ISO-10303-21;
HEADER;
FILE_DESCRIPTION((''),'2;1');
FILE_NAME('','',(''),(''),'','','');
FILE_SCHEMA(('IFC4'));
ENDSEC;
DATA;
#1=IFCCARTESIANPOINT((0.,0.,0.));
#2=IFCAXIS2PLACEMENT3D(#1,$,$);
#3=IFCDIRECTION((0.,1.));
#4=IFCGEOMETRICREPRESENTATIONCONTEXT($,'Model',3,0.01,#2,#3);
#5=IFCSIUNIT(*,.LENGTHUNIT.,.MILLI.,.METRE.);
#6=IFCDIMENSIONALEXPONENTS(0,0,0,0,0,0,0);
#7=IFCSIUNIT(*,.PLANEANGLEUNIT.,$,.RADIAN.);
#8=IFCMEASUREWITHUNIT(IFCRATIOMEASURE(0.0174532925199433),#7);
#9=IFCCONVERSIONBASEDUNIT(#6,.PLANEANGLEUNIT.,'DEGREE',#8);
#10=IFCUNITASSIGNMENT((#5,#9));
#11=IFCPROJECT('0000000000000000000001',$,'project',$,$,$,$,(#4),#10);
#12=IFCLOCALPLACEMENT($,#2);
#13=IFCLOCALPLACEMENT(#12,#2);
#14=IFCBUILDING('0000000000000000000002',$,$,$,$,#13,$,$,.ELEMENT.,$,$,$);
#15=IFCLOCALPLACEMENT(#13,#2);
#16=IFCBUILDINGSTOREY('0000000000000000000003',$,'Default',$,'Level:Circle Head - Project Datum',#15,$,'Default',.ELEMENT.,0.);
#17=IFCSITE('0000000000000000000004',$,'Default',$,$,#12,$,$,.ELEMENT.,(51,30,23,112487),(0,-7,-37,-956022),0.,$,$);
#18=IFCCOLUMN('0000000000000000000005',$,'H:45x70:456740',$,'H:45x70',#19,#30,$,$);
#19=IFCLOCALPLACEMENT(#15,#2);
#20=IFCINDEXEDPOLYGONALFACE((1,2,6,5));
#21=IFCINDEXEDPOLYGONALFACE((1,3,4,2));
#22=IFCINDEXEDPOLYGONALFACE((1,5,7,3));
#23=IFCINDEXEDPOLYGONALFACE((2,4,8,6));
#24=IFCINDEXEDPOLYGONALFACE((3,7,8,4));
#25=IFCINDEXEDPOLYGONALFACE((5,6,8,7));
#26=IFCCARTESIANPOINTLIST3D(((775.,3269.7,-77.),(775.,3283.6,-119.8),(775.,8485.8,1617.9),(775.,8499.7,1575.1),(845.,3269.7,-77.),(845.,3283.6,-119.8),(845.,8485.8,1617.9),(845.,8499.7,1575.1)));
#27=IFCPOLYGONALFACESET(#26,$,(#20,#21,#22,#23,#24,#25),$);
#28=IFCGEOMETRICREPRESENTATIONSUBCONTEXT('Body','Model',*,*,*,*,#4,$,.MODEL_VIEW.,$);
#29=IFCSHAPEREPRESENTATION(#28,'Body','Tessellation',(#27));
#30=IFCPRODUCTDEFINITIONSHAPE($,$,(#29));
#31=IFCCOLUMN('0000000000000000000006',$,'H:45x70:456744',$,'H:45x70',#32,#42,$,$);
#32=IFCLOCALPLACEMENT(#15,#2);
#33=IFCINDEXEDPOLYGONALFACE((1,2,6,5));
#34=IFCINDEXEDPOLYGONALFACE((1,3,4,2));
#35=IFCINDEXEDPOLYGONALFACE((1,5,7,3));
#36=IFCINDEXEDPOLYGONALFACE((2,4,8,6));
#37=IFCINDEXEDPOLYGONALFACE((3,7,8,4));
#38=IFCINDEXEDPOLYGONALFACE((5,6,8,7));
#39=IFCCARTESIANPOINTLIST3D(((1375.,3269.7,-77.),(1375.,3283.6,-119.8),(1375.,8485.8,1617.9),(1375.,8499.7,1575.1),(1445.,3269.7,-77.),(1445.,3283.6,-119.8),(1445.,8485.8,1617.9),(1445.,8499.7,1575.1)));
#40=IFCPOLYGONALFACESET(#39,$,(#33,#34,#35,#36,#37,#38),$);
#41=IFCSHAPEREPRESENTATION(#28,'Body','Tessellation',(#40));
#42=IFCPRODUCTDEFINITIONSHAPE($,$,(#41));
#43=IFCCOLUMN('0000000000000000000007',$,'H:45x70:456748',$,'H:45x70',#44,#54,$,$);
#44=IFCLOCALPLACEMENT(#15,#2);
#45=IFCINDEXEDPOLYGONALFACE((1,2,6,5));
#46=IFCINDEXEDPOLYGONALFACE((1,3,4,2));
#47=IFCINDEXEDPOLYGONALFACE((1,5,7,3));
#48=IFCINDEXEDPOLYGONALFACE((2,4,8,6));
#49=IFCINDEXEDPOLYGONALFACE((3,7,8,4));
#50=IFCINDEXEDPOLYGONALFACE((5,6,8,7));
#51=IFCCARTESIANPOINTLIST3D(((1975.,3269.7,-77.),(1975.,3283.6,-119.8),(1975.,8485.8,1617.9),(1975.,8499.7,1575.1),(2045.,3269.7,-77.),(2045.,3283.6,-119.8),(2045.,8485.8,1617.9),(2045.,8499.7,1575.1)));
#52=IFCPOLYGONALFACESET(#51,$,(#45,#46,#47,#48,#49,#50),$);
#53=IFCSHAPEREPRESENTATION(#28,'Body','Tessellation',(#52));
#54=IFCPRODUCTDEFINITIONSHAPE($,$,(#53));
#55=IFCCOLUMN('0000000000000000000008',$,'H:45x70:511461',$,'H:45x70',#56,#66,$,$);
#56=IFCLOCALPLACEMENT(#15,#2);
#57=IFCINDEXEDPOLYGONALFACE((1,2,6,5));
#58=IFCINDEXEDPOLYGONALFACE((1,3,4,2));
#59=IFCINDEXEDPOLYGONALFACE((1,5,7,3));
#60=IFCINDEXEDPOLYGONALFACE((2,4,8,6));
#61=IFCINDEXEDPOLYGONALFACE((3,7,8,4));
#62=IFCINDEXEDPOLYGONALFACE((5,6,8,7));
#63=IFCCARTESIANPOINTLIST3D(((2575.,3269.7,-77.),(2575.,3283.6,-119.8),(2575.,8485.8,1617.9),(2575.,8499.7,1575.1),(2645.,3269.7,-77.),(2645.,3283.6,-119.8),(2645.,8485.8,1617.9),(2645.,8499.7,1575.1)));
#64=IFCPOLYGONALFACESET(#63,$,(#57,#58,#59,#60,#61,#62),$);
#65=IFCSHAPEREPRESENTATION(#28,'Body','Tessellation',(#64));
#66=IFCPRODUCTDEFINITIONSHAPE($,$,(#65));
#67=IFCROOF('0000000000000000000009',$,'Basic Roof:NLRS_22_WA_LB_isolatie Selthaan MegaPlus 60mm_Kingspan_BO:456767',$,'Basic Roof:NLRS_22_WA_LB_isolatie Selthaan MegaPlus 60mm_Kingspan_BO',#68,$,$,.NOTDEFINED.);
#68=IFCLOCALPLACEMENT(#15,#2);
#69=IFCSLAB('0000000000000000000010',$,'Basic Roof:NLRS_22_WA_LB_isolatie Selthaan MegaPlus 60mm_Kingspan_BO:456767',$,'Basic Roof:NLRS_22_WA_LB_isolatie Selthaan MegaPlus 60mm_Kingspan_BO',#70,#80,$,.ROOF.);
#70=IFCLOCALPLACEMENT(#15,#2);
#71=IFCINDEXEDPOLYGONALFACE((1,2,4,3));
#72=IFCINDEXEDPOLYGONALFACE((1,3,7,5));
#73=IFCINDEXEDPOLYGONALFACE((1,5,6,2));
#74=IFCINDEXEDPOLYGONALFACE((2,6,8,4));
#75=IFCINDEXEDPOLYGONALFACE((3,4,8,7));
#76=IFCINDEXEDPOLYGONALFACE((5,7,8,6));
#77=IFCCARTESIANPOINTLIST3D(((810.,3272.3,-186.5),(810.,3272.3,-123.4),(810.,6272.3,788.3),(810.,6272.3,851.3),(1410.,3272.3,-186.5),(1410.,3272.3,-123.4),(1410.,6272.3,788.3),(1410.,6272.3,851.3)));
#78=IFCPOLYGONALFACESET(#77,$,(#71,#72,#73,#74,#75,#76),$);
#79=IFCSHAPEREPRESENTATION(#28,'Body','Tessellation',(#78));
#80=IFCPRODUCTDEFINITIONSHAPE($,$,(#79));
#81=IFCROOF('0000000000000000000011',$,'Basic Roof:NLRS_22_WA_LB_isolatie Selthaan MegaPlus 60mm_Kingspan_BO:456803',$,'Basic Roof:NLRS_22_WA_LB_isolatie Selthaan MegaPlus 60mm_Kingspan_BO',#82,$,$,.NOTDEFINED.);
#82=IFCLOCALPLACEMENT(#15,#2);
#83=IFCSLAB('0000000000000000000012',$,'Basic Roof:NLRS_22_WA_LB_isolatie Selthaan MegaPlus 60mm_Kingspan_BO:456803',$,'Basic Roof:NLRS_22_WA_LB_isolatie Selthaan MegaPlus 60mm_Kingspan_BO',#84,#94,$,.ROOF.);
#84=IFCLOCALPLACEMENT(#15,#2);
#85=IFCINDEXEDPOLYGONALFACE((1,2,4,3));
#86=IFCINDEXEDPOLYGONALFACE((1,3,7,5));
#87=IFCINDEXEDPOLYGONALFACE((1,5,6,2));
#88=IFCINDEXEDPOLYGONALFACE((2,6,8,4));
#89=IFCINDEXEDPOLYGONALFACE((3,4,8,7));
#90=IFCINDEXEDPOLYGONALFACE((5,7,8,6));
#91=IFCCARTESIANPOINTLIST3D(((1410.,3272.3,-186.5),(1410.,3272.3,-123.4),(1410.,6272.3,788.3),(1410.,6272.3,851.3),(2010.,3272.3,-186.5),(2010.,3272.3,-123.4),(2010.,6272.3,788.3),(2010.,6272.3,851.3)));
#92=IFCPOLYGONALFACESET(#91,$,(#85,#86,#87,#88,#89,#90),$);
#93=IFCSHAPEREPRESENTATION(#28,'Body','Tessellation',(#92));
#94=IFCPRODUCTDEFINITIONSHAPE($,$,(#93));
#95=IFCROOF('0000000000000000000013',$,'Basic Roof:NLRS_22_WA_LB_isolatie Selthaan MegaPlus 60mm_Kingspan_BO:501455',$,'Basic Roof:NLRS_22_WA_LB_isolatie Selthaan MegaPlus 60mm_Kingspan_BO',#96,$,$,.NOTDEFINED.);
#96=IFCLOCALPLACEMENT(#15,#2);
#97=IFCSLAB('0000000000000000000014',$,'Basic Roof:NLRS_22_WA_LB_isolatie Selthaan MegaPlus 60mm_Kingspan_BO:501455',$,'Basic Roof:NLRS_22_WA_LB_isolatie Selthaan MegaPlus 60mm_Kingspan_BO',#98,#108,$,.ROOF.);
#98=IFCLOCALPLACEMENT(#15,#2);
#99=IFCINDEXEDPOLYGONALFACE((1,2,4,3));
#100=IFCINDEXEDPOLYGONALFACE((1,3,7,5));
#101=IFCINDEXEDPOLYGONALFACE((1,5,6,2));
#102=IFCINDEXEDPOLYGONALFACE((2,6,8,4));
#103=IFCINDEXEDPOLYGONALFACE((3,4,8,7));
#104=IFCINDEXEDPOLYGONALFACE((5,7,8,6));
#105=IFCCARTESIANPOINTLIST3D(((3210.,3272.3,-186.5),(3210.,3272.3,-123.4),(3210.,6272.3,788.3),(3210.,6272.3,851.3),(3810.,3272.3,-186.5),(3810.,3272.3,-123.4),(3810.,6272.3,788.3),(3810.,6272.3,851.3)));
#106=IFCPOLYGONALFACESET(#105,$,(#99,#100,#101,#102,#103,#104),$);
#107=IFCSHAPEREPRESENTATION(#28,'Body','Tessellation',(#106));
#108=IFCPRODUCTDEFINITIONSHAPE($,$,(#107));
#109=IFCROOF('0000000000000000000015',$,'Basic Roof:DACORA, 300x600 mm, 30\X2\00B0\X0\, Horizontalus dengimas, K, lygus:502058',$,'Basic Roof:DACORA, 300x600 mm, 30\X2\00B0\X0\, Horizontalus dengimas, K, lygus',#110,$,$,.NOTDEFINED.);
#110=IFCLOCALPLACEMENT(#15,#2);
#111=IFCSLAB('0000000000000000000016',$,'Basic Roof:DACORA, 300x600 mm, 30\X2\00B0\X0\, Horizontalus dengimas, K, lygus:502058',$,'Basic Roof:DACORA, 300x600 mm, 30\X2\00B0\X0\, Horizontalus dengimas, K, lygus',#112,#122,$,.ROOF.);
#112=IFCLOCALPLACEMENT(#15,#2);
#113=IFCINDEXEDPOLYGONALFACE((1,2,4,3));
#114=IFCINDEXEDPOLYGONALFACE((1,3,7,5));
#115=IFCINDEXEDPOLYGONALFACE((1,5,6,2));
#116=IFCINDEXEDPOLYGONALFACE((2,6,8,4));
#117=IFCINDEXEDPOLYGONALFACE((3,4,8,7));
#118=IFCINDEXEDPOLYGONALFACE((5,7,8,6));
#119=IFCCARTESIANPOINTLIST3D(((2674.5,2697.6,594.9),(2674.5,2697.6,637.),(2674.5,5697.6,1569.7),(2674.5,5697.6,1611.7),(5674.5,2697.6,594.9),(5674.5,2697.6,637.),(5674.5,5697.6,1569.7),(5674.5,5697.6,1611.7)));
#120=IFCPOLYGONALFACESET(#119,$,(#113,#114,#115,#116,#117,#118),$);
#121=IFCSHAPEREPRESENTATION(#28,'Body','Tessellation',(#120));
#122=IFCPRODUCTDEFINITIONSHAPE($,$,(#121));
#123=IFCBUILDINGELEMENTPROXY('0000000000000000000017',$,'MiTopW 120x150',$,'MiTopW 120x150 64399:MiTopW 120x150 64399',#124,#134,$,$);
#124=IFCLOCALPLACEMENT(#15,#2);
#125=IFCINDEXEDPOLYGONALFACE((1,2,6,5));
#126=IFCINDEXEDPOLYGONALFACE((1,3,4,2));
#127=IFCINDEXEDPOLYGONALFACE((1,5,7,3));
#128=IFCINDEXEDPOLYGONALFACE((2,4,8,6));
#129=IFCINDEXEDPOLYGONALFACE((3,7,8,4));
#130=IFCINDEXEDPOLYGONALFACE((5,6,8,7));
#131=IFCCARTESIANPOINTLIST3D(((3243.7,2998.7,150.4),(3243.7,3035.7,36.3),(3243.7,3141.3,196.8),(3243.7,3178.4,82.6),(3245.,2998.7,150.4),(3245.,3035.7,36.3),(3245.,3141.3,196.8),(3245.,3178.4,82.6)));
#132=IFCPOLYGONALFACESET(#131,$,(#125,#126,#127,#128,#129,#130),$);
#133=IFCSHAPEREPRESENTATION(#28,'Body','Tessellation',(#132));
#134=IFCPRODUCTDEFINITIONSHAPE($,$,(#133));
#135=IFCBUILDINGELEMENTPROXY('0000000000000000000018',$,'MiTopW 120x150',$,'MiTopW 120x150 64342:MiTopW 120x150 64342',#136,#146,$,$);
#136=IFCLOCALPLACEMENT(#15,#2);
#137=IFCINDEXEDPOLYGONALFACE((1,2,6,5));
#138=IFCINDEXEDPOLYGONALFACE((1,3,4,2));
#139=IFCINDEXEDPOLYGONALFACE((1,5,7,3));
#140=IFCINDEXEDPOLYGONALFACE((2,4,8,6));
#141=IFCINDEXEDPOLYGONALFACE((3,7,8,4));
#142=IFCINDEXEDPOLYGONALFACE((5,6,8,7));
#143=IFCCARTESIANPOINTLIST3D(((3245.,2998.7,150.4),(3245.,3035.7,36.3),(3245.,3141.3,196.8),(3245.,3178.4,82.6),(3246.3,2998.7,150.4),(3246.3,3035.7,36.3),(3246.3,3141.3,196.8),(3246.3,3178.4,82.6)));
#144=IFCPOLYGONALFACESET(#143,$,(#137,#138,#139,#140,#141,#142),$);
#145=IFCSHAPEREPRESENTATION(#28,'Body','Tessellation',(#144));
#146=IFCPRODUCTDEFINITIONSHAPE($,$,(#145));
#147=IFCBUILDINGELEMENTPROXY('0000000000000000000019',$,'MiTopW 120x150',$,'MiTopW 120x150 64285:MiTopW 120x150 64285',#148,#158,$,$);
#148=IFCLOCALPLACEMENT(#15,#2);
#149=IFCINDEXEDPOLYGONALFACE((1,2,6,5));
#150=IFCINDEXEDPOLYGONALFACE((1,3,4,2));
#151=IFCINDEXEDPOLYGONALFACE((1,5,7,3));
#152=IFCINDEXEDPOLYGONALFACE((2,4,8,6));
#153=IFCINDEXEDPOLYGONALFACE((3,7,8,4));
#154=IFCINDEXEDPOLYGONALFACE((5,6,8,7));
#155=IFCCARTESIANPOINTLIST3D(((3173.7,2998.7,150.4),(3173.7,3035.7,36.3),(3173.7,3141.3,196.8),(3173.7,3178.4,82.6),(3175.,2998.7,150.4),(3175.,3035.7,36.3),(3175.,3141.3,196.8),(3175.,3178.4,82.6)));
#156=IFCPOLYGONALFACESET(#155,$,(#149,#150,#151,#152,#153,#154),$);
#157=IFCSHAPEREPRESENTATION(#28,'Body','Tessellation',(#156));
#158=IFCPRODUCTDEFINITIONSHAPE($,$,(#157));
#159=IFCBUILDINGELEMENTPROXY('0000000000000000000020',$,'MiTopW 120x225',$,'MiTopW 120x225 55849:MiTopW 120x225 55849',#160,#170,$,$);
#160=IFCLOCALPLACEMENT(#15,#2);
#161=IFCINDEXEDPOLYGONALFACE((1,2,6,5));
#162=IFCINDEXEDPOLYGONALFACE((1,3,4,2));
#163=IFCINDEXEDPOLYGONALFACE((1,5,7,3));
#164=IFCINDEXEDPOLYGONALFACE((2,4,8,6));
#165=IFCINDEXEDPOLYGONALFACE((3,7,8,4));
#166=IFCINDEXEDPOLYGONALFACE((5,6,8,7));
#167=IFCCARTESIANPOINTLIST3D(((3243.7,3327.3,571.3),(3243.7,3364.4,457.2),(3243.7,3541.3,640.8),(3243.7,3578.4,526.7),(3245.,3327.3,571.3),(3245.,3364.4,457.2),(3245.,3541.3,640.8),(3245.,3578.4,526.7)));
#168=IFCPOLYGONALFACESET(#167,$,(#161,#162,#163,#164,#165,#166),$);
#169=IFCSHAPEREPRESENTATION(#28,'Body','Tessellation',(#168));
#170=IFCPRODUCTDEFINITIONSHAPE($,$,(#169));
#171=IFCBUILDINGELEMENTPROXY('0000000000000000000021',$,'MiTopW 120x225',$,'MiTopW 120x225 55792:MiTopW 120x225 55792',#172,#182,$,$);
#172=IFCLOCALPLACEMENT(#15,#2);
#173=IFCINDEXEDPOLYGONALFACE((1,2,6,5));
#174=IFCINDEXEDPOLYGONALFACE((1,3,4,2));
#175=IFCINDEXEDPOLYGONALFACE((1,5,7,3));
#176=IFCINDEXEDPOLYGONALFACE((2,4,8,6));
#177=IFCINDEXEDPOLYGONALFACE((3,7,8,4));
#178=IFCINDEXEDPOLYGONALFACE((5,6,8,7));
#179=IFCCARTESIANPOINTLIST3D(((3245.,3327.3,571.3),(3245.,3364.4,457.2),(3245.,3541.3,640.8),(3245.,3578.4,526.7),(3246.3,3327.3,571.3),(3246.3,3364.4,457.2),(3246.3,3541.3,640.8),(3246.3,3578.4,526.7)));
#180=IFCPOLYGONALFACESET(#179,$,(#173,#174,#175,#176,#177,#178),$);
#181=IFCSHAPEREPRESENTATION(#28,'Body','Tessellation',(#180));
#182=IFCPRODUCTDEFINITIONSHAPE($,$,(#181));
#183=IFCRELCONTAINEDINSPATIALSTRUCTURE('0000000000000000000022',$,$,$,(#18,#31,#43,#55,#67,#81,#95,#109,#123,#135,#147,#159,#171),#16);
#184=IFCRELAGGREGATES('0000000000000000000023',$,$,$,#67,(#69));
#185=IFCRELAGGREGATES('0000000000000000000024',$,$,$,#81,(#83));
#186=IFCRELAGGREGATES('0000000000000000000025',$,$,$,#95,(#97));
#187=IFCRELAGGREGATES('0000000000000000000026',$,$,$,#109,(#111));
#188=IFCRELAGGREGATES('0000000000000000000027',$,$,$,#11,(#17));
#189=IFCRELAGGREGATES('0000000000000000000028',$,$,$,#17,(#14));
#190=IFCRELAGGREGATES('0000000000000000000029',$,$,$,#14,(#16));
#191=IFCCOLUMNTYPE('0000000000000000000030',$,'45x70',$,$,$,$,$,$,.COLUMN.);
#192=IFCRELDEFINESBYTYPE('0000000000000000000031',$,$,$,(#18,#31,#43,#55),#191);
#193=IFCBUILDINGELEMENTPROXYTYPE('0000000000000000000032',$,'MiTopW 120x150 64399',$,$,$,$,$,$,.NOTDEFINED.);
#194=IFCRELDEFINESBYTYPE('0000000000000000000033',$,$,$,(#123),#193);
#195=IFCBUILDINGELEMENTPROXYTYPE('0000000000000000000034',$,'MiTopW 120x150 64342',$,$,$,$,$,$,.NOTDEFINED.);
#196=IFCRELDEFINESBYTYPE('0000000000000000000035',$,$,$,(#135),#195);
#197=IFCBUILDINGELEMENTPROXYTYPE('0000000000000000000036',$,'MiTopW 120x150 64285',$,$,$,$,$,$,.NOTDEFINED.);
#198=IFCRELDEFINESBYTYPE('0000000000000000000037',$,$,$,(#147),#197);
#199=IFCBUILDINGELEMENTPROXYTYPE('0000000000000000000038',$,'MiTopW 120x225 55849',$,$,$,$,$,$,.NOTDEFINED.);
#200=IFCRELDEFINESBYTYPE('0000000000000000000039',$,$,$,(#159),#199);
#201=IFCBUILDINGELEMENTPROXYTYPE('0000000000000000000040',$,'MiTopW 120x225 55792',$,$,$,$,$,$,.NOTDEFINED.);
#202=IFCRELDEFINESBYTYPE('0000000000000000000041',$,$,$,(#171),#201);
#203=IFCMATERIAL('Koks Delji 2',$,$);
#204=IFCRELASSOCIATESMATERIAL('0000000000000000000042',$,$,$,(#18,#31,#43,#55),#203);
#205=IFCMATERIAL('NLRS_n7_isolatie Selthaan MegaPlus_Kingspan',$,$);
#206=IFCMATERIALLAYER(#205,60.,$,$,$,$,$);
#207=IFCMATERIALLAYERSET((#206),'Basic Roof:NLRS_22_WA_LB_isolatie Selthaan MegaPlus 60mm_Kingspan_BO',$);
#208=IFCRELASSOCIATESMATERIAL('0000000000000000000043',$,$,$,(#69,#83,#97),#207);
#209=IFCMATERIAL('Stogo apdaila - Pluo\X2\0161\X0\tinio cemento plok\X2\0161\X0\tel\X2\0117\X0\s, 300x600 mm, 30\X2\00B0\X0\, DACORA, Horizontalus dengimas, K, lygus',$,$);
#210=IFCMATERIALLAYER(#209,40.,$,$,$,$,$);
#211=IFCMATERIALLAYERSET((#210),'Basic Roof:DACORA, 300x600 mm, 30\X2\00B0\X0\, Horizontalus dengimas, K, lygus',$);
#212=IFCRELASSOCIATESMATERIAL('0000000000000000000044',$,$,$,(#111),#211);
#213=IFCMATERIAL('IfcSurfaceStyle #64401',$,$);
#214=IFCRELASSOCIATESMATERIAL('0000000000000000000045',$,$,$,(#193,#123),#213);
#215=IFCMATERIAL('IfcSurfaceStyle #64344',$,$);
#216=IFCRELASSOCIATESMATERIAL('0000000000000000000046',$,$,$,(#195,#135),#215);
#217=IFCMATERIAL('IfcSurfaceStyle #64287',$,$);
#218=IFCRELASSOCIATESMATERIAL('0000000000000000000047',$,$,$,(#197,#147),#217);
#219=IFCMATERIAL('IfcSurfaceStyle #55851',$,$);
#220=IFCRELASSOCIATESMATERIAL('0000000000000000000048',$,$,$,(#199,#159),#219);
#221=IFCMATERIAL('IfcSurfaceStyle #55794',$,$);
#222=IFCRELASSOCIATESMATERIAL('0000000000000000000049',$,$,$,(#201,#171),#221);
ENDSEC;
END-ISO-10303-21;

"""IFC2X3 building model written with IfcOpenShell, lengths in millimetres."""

from ifc_helpers import new_model, entity, si_unit, converted_unit, direction, frame, frame_2d, origin, place, context, subcontext, project, spatial, polyline, rectangle, outline, extrude, source, transform, mapped, material, layer, layer_set, type_object, type_shapes, element, aggregate, save


model = new_model("IFC2X3")

# Units and contexts
model_context = context("Model", 3, precision=0.01, world=origin(), true_north=direction((0.0, 1.0)))
body_context = subcontext(model_context, "Body", "Model", "MODEL_VIEW")
ifc_project = project(units=[si_unit("LENGTHUNIT", "METRE", prefix="MILLI"), converted_unit("PLANEANGLEUNIT", "DEGREE", entity("IfcRatioMeasure", 0.0174532925199433), si_unit("PLANEANGLEUNIT", "RADIAN"), dimensions=[0, 0, 0, 0, 0, 0, 0])], contexts=[model_context])

# Site, building, storey
site_placement = place(None, origin())
site = spatial("IfcSite", under=ifc_project, at=site_placement, Name="Default", CompositionType="ELEMENT", RefLatitude=(51, 30, 23, 112487), RefLongitude=(0, -7, -37, -956022), RefElevation=0.0)
building_placement = place(site_placement, origin())
building = spatial("IfcBuilding", under=site, at=building_placement, CompositionType="ELEMENT")
storey_placement = place(building_placement, origin())
storey = spatial("IfcBuildingStorey", under=building, at=storey_placement, Name="Default", ObjectType="Level:Circle Head - Project Datum", LongName="Default", CompositionType="ELEMENT", Elevation=0.0)

# Columns
ifc_material_1 = material(Name="Koks Delji 2")
column_type_1 = type_object("IfcColumnType", Name="45x70", PredefinedType="COLUMN")
shared_shape_1 = source(origin(), body_context, "Body", "SweptSolid", [
    extrude(rectangle(XDim=5484.5, YDim=70.0, at=frame_2d((0.0, 0.0), x_axis=(1.0, 0.0))), frame((2608.0, 237.8, 847.4), z_axis=(-0.309017, 0.0, 0.951057), x_axis=(-0.951057, 0.0, -0.309017)), (0.0, 0.0, 1.0), 45.0),
])
type_shapes(column_type_1, [shared_shape_1])
for number, where, z_axis, x_axis, name in (
    (1, (1047.8, 3283.6, -119.8), (0.0, 0.0, 1.0), (0.0, 1.0, 0.0), "H:45x70:456740"),
    (2, (1647.8, 3283.6, -119.8), (0.0, 0.0, 1.0), (0.0, 1.0, 0.0), "H:45x70:456744"),
    (3, (2247.8, 3283.6, -119.8), (0.0, 0.0, 1.0), (0.0, 1.0, 0.0), "H:45x70:456748"),
    (4, (2847.8, 3283.6, -119.8), (0.0, 0.0, 1.0), (0.0, 1.0, 0.0), "H:45x70:511461"),
):
    element("IfcColumn", number, at=place(storey_placement, frame(where, z_axis=z_axis, x_axis=x_axis)), inside=storey, type_object=column_type_1, material=ifc_material_1, Name=name, ObjectType="H:45x70", context=body_context, shape_type="MappedRepresentation", body=[
        mapped(shared_shape_1, transform((0.0, 0.0, 0.0), scale=1.0)),
    ])

# Roofs, slabs
roof_1_placement = place(storey_placement, frame((810.0, 3272.3, -186.5)))
roof_1 = element("IfcRoof", 5, at=roof_1_placement, inside=storey, Name="Basic Roof:NLRS_22_WA_LB_isolatie Selthaan MegaPlus 60mm_Kingspan_BO:456767", ObjectType="Basic Roof:NLRS_22_WA_LB_isolatie Selthaan MegaPlus 60mm_Kingspan_BO", ShapeType="NOTDEFINED")
ifc_material_2 = material(Name="NLRS_n7_isolatie Selthaan MegaPlus_Kingspan")
ifc_layer_1 = layer(ifc_material_2, 60.0)
ifc_layer_set_1 = layer_set([ifc_layer_1], Name="Basic Roof:NLRS_22_WA_LB_isolatie Selthaan MegaPlus 60mm_Kingspan_BO")
slab_1_placement = place(roof_1_placement, origin())
slab_1 = element("IfcSlab", 6, at=slab_1_placement, material=ifc_layer_set_1, Name="Basic Roof:NLRS_22_WA_LB_isolatie Selthaan MegaPlus 60mm_Kingspan_BO:456767", ObjectType="Basic Roof:NLRS_22_WA_LB_isolatie Selthaan MegaPlus 60mm_Kingspan_BO", PredefinedType="ROOF", context=body_context, shape_type="SweptSolid", body=[
    extrude(rectangle(XDim=600.0, YDim=3154.4, at=frame_2d((0.0, 0.0), x_axis=(-1.0, 0.0))), frame((300.0, 1500.0, 487.4), z_axis=(0.0, -0.309017, 0.951057), x_axis=(1.0, 0.0, 0.0)), (0.0, 0.309017, 0.951057), 63.1),
])
aggregate(roof_1, [slab_1])
roof_2_placement = place(storey_placement, frame((1410.0, 3272.3, -186.5)))
roof_2 = element("IfcRoof", 7, at=roof_2_placement, inside=storey, Name="Basic Roof:NLRS_22_WA_LB_isolatie Selthaan MegaPlus 60mm_Kingspan_BO:456803", ObjectType="Basic Roof:NLRS_22_WA_LB_isolatie Selthaan MegaPlus 60mm_Kingspan_BO", ShapeType="NOTDEFINED")
slab_2_placement = place(roof_2_placement, origin())
slab_2 = element("IfcSlab", 8, at=slab_2_placement, material=ifc_layer_set_1, Name="Basic Roof:NLRS_22_WA_LB_isolatie Selthaan MegaPlus 60mm_Kingspan_BO:456803", ObjectType="Basic Roof:NLRS_22_WA_LB_isolatie Selthaan MegaPlus 60mm_Kingspan_BO", PredefinedType="ROOF", context=body_context, shape_type="SweptSolid", body=[
    extrude(rectangle(XDim=600.0, YDim=3154.4, at=frame_2d((0.0, 0.0), x_axis=(-1.0, 0.0))), frame((300.0, 1500.0, 487.4), z_axis=(0.0, -0.309017, 0.951057), x_axis=(1.0, 0.0, 0.0)), (0.0, 0.309017, 0.951057), 63.1),
])
aggregate(roof_2, [slab_2])
roof_3_placement = place(storey_placement, frame((3210.0, 3272.3, -186.5)))
roof_3 = element("IfcRoof", 9, at=roof_3_placement, inside=storey, Name="Basic Roof:NLRS_22_WA_LB_isolatie Selthaan MegaPlus 60mm_Kingspan_BO:501455", ObjectType="Basic Roof:NLRS_22_WA_LB_isolatie Selthaan MegaPlus 60mm_Kingspan_BO", ShapeType="NOTDEFINED")
slab_3_placement = place(roof_3_placement, origin())
slab_3 = element("IfcSlab", 10, at=slab_3_placement, material=ifc_layer_set_1, Name="Basic Roof:NLRS_22_WA_LB_isolatie Selthaan MegaPlus 60mm_Kingspan_BO:501455", ObjectType="Basic Roof:NLRS_22_WA_LB_isolatie Selthaan MegaPlus 60mm_Kingspan_BO", PredefinedType="ROOF", context=body_context, shape_type="SweptSolid", body=[
    extrude(rectangle(XDim=600.0, YDim=3154.4, at=frame_2d((0.0, 0.0), x_axis=(-1.0, 0.0))), frame((300.0, 1500.0, 487.4), z_axis=(0.0, -0.309017, 0.951057), x_axis=(1.0, 0.0, 0.0)), (0.0, 0.309017, 0.951057), 63.1),
])
aggregate(roof_3, [slab_3])
roof_4_placement = place(storey_placement, frame((2674.5, 2697.6, 594.9)))
roof_4 = element("IfcRoof", 11, at=roof_4_placement, inside=storey, Name="Basic Roof:DACORA, 300x600 mm, 30°, Horizontalus dengimas, K, lygus:502058", ObjectType="Basic Roof:DACORA, 300x600 mm, 30°, Horizontalus dengimas, K, lygus", ShapeType="NOTDEFINED")
ifc_material_3 = material(Name="Stogo apdaila - Pluoštinio cemento plokštelės, 300x600 mm, 30°, DACORA, Horizontalus dengimas, K, lygus")
ifc_layer_2 = layer(ifc_material_3, 40.0)
ifc_layer_set_2 = layer_set([ifc_layer_2], Name="Basic Roof:DACORA, 300x600 mm, 30°, Horizontalus dengimas, K, lygus")
slab_4_placement = place(roof_4_placement, origin())
slab_4 = element("IfcSlab", 12, at=slab_4_placement, material=ifc_layer_set_2, Name="Basic Roof:DACORA, 300x600 mm, 30°, Horizontalus dengimas, K, lygus:502058", ObjectType="Basic Roof:DACORA, 300x600 mm, 30°, Horizontalus dengimas, K, lygus", PredefinedType="ROOF", context=body_context, shape_type="SweptSolid", body=[
    extrude(rectangle(XDim=3154.4, YDim=3000.0, at=frame_2d((0.0, 0.0), x_axis=(0.0, -1.0))), frame((1500.0, 1500.0, 487.4), z_axis=(0.0, -0.309017, 0.951057), x_axis=(1.0, 0.0, 0.0)), (0.0, 0.309017, 0.951057), 42.1),
])
aggregate(roof_4, [slab_4])

# Building element proxies
ifc_material_4 = material(Name="IfcSurfaceStyle #64401")
building_element_proxy_type_1 = type_object("IfcBuildingElementProxyType", Name="MiTopW 120x150 64399", PredefinedType="NOTDEFINED", material=ifc_material_4)
shared_shape_2 = source(origin(), body_context, "Body", "SweptSolid", [
    extrude(outline(polyline([(-75.0, -60.0), (75.0, -60.0), (75.0, 60.0), (-75.0, 60.0), (-75.0, -60.0)])), frame((75.0, 60.0, 0.0), z_axis=(0.0, 0.0, 1.0), x_axis=(-1.0, 0.0, 0.0)), (0.0, 0.0, 1.0), 1.3),
])
type_shapes(building_element_proxy_type_1, [shared_shape_2])
proxy_1_placement = place(building_placement, frame((3245.0, 2998.7, 150.4), z_axis=(-1.0, 0.0, 0.0), x_axis=(0.0, 0.951057, 0.309017)))
element("IfcBuildingElementProxy", 13, at=proxy_1_placement, inside=storey, type_object=building_element_proxy_type_1, material=ifc_material_4, Name="MiTopW 120x150", ObjectType="MiTopW 120x150 64399:MiTopW 120x150 64399", context=body_context, shape_type="MappedRepresentation", body=[
    mapped(shared_shape_2, transform((0.0, 0.0, 0.0), scale=1.0)),
])
ifc_material_5 = material(Name="IfcSurfaceStyle #64344")
building_element_proxy_type_2 = type_object("IfcBuildingElementProxyType", Name="MiTopW 120x150 64342", PredefinedType="NOTDEFINED", material=ifc_material_5)
shared_shape_3 = source(origin(), body_context, "Body", "SweptSolid", [
    extrude(outline(polyline([(-75.0, -60.0), (75.0, -60.0), (75.0, 60.0), (-75.0, 60.0), (-75.0, -60.0)])), frame((75.0, 60.0, 0.0), z_axis=(0.0, 0.0, 1.0), x_axis=(-1.0, 0.0, 0.0)), (0.0, 0.0, 1.0), 1.3),
])
type_shapes(building_element_proxy_type_2, [shared_shape_3])
proxy_2_placement = place(building_placement, frame((3246.3, 2998.7, 150.4), z_axis=(-1.0, 0.0, 0.0), x_axis=(0.0, 0.951057, 0.309017)))
element("IfcBuildingElementProxy", 14, at=proxy_2_placement, inside=storey, type_object=building_element_proxy_type_2, material=ifc_material_5, Name="MiTopW 120x150", ObjectType="MiTopW 120x150 64342:MiTopW 120x150 64342", context=body_context, shape_type="MappedRepresentation", body=[
    mapped(shared_shape_3, transform((0.0, 0.0, 0.0), scale=1.0)),
])
ifc_material_6 = material(Name="IfcSurfaceStyle #64287")
building_element_proxy_type_3 = type_object("IfcBuildingElementProxyType", Name="MiTopW 120x150 64285", PredefinedType="NOTDEFINED", material=ifc_material_6)
shared_shape_4 = source(origin(), body_context, "Body", "SweptSolid", [
    extrude(outline(polyline([(-75.0, -60.0), (75.0, -60.0), (75.0, 60.0), (-75.0, 60.0), (-75.0, -60.0)])), frame((75.0, 60.0, 0.0), z_axis=(0.0, 0.0, 1.0), x_axis=(-1.0, 0.0, 0.0)), (0.0, 0.0, 1.0), 1.3),
])
type_shapes(building_element_proxy_type_3, [shared_shape_4])
proxy_3_placement = place(building_placement, frame((3175.0, 2998.7, 150.4), z_axis=(-1.0, 0.0, 0.0), x_axis=(0.0, 0.951057, 0.309017)))
element("IfcBuildingElementProxy", 15, at=proxy_3_placement, inside=storey, type_object=building_element_proxy_type_3, material=ifc_material_6, Name="MiTopW 120x150", ObjectType="MiTopW 120x150 64285:MiTopW 120x150 64285", context=body_context, shape_type="MappedRepresentation", body=[
    mapped(shared_shape_4, transform((0.0, 0.0, 0.0), scale=1.0)),
])
ifc_material_7 = material(Name="IfcSurfaceStyle #55851")
building_element_proxy_type_4 = type_object("IfcBuildingElementProxyType", Name="MiTopW 120x225 55849", PredefinedType="NOTDEFINED", material=ifc_material_7)
shared_shape_5 = source(origin(), body_context, "Body", "SweptSolid", [
    extrude(outline(polyline([(-112.5, -60.0), (112.5, -60.0), (112.5, 60.0), (-112.5, 60.0), (-112.5, -60.0)])), frame((112.5, 60.0, 0.0), z_axis=(0.0, 0.0, 1.0), x_axis=(-1.0, 0.0, 0.0)), (0.0, 0.0, 1.0), 1.3),
])
type_shapes(building_element_proxy_type_4, [shared_shape_5])
proxy_4_placement = place(building_placement, frame((3245.0, 3327.3, 571.3), z_axis=(-1.0, 0.0, 0.0), x_axis=(0.0, 0.951057, 0.309017)))
element("IfcBuildingElementProxy", 16, at=proxy_4_placement, inside=storey, type_object=building_element_proxy_type_4, material=ifc_material_7, Name="MiTopW 120x225", ObjectType="MiTopW 120x225 55849:MiTopW 120x225 55849", context=body_context, shape_type="MappedRepresentation", body=[
    mapped(shared_shape_5, transform((0.0, 0.0, 0.0), scale=1.0)),
])
ifc_material_8 = material(Name="IfcSurfaceStyle #55794")
building_element_proxy_type_5 = type_object("IfcBuildingElementProxyType", Name="MiTopW 120x225 55792", PredefinedType="NOTDEFINED", material=ifc_material_8)
shared_shape_6 = source(origin(), body_context, "Body", "SweptSolid", [
    extrude(outline(polyline([(-112.5, -60.0), (112.5, -60.0), (112.5, 60.0), (-112.5, 60.0), (-112.5, -60.0)])), frame((112.5, 60.0, 0.0), z_axis=(0.0, 0.0, 1.0), x_axis=(-1.0, 0.0, 0.0)), (0.0, 0.0, 1.0), 1.3),
])
type_shapes(building_element_proxy_type_5, [shared_shape_6])
proxy_5_placement = place(building_placement, frame((3246.3, 3327.3, 571.3), z_axis=(-1.0, 0.0, 0.0), x_axis=(0.0, 0.951057, 0.309017)))
element("IfcBuildingElementProxy", 17, at=proxy_5_placement, inside=storey, type_object=building_element_proxy_type_5, material=ifc_material_8, Name="MiTopW 120x225", ObjectType="MiTopW 120x225 55792:MiTopW 120x225 55792", context=body_context, shape_type="MappedRepresentation", body=[
    mapped(shared_shape_6, transform((0.0, 0.0, 0.0), scale=1.0)),
])

save(model, "model.ifc")
